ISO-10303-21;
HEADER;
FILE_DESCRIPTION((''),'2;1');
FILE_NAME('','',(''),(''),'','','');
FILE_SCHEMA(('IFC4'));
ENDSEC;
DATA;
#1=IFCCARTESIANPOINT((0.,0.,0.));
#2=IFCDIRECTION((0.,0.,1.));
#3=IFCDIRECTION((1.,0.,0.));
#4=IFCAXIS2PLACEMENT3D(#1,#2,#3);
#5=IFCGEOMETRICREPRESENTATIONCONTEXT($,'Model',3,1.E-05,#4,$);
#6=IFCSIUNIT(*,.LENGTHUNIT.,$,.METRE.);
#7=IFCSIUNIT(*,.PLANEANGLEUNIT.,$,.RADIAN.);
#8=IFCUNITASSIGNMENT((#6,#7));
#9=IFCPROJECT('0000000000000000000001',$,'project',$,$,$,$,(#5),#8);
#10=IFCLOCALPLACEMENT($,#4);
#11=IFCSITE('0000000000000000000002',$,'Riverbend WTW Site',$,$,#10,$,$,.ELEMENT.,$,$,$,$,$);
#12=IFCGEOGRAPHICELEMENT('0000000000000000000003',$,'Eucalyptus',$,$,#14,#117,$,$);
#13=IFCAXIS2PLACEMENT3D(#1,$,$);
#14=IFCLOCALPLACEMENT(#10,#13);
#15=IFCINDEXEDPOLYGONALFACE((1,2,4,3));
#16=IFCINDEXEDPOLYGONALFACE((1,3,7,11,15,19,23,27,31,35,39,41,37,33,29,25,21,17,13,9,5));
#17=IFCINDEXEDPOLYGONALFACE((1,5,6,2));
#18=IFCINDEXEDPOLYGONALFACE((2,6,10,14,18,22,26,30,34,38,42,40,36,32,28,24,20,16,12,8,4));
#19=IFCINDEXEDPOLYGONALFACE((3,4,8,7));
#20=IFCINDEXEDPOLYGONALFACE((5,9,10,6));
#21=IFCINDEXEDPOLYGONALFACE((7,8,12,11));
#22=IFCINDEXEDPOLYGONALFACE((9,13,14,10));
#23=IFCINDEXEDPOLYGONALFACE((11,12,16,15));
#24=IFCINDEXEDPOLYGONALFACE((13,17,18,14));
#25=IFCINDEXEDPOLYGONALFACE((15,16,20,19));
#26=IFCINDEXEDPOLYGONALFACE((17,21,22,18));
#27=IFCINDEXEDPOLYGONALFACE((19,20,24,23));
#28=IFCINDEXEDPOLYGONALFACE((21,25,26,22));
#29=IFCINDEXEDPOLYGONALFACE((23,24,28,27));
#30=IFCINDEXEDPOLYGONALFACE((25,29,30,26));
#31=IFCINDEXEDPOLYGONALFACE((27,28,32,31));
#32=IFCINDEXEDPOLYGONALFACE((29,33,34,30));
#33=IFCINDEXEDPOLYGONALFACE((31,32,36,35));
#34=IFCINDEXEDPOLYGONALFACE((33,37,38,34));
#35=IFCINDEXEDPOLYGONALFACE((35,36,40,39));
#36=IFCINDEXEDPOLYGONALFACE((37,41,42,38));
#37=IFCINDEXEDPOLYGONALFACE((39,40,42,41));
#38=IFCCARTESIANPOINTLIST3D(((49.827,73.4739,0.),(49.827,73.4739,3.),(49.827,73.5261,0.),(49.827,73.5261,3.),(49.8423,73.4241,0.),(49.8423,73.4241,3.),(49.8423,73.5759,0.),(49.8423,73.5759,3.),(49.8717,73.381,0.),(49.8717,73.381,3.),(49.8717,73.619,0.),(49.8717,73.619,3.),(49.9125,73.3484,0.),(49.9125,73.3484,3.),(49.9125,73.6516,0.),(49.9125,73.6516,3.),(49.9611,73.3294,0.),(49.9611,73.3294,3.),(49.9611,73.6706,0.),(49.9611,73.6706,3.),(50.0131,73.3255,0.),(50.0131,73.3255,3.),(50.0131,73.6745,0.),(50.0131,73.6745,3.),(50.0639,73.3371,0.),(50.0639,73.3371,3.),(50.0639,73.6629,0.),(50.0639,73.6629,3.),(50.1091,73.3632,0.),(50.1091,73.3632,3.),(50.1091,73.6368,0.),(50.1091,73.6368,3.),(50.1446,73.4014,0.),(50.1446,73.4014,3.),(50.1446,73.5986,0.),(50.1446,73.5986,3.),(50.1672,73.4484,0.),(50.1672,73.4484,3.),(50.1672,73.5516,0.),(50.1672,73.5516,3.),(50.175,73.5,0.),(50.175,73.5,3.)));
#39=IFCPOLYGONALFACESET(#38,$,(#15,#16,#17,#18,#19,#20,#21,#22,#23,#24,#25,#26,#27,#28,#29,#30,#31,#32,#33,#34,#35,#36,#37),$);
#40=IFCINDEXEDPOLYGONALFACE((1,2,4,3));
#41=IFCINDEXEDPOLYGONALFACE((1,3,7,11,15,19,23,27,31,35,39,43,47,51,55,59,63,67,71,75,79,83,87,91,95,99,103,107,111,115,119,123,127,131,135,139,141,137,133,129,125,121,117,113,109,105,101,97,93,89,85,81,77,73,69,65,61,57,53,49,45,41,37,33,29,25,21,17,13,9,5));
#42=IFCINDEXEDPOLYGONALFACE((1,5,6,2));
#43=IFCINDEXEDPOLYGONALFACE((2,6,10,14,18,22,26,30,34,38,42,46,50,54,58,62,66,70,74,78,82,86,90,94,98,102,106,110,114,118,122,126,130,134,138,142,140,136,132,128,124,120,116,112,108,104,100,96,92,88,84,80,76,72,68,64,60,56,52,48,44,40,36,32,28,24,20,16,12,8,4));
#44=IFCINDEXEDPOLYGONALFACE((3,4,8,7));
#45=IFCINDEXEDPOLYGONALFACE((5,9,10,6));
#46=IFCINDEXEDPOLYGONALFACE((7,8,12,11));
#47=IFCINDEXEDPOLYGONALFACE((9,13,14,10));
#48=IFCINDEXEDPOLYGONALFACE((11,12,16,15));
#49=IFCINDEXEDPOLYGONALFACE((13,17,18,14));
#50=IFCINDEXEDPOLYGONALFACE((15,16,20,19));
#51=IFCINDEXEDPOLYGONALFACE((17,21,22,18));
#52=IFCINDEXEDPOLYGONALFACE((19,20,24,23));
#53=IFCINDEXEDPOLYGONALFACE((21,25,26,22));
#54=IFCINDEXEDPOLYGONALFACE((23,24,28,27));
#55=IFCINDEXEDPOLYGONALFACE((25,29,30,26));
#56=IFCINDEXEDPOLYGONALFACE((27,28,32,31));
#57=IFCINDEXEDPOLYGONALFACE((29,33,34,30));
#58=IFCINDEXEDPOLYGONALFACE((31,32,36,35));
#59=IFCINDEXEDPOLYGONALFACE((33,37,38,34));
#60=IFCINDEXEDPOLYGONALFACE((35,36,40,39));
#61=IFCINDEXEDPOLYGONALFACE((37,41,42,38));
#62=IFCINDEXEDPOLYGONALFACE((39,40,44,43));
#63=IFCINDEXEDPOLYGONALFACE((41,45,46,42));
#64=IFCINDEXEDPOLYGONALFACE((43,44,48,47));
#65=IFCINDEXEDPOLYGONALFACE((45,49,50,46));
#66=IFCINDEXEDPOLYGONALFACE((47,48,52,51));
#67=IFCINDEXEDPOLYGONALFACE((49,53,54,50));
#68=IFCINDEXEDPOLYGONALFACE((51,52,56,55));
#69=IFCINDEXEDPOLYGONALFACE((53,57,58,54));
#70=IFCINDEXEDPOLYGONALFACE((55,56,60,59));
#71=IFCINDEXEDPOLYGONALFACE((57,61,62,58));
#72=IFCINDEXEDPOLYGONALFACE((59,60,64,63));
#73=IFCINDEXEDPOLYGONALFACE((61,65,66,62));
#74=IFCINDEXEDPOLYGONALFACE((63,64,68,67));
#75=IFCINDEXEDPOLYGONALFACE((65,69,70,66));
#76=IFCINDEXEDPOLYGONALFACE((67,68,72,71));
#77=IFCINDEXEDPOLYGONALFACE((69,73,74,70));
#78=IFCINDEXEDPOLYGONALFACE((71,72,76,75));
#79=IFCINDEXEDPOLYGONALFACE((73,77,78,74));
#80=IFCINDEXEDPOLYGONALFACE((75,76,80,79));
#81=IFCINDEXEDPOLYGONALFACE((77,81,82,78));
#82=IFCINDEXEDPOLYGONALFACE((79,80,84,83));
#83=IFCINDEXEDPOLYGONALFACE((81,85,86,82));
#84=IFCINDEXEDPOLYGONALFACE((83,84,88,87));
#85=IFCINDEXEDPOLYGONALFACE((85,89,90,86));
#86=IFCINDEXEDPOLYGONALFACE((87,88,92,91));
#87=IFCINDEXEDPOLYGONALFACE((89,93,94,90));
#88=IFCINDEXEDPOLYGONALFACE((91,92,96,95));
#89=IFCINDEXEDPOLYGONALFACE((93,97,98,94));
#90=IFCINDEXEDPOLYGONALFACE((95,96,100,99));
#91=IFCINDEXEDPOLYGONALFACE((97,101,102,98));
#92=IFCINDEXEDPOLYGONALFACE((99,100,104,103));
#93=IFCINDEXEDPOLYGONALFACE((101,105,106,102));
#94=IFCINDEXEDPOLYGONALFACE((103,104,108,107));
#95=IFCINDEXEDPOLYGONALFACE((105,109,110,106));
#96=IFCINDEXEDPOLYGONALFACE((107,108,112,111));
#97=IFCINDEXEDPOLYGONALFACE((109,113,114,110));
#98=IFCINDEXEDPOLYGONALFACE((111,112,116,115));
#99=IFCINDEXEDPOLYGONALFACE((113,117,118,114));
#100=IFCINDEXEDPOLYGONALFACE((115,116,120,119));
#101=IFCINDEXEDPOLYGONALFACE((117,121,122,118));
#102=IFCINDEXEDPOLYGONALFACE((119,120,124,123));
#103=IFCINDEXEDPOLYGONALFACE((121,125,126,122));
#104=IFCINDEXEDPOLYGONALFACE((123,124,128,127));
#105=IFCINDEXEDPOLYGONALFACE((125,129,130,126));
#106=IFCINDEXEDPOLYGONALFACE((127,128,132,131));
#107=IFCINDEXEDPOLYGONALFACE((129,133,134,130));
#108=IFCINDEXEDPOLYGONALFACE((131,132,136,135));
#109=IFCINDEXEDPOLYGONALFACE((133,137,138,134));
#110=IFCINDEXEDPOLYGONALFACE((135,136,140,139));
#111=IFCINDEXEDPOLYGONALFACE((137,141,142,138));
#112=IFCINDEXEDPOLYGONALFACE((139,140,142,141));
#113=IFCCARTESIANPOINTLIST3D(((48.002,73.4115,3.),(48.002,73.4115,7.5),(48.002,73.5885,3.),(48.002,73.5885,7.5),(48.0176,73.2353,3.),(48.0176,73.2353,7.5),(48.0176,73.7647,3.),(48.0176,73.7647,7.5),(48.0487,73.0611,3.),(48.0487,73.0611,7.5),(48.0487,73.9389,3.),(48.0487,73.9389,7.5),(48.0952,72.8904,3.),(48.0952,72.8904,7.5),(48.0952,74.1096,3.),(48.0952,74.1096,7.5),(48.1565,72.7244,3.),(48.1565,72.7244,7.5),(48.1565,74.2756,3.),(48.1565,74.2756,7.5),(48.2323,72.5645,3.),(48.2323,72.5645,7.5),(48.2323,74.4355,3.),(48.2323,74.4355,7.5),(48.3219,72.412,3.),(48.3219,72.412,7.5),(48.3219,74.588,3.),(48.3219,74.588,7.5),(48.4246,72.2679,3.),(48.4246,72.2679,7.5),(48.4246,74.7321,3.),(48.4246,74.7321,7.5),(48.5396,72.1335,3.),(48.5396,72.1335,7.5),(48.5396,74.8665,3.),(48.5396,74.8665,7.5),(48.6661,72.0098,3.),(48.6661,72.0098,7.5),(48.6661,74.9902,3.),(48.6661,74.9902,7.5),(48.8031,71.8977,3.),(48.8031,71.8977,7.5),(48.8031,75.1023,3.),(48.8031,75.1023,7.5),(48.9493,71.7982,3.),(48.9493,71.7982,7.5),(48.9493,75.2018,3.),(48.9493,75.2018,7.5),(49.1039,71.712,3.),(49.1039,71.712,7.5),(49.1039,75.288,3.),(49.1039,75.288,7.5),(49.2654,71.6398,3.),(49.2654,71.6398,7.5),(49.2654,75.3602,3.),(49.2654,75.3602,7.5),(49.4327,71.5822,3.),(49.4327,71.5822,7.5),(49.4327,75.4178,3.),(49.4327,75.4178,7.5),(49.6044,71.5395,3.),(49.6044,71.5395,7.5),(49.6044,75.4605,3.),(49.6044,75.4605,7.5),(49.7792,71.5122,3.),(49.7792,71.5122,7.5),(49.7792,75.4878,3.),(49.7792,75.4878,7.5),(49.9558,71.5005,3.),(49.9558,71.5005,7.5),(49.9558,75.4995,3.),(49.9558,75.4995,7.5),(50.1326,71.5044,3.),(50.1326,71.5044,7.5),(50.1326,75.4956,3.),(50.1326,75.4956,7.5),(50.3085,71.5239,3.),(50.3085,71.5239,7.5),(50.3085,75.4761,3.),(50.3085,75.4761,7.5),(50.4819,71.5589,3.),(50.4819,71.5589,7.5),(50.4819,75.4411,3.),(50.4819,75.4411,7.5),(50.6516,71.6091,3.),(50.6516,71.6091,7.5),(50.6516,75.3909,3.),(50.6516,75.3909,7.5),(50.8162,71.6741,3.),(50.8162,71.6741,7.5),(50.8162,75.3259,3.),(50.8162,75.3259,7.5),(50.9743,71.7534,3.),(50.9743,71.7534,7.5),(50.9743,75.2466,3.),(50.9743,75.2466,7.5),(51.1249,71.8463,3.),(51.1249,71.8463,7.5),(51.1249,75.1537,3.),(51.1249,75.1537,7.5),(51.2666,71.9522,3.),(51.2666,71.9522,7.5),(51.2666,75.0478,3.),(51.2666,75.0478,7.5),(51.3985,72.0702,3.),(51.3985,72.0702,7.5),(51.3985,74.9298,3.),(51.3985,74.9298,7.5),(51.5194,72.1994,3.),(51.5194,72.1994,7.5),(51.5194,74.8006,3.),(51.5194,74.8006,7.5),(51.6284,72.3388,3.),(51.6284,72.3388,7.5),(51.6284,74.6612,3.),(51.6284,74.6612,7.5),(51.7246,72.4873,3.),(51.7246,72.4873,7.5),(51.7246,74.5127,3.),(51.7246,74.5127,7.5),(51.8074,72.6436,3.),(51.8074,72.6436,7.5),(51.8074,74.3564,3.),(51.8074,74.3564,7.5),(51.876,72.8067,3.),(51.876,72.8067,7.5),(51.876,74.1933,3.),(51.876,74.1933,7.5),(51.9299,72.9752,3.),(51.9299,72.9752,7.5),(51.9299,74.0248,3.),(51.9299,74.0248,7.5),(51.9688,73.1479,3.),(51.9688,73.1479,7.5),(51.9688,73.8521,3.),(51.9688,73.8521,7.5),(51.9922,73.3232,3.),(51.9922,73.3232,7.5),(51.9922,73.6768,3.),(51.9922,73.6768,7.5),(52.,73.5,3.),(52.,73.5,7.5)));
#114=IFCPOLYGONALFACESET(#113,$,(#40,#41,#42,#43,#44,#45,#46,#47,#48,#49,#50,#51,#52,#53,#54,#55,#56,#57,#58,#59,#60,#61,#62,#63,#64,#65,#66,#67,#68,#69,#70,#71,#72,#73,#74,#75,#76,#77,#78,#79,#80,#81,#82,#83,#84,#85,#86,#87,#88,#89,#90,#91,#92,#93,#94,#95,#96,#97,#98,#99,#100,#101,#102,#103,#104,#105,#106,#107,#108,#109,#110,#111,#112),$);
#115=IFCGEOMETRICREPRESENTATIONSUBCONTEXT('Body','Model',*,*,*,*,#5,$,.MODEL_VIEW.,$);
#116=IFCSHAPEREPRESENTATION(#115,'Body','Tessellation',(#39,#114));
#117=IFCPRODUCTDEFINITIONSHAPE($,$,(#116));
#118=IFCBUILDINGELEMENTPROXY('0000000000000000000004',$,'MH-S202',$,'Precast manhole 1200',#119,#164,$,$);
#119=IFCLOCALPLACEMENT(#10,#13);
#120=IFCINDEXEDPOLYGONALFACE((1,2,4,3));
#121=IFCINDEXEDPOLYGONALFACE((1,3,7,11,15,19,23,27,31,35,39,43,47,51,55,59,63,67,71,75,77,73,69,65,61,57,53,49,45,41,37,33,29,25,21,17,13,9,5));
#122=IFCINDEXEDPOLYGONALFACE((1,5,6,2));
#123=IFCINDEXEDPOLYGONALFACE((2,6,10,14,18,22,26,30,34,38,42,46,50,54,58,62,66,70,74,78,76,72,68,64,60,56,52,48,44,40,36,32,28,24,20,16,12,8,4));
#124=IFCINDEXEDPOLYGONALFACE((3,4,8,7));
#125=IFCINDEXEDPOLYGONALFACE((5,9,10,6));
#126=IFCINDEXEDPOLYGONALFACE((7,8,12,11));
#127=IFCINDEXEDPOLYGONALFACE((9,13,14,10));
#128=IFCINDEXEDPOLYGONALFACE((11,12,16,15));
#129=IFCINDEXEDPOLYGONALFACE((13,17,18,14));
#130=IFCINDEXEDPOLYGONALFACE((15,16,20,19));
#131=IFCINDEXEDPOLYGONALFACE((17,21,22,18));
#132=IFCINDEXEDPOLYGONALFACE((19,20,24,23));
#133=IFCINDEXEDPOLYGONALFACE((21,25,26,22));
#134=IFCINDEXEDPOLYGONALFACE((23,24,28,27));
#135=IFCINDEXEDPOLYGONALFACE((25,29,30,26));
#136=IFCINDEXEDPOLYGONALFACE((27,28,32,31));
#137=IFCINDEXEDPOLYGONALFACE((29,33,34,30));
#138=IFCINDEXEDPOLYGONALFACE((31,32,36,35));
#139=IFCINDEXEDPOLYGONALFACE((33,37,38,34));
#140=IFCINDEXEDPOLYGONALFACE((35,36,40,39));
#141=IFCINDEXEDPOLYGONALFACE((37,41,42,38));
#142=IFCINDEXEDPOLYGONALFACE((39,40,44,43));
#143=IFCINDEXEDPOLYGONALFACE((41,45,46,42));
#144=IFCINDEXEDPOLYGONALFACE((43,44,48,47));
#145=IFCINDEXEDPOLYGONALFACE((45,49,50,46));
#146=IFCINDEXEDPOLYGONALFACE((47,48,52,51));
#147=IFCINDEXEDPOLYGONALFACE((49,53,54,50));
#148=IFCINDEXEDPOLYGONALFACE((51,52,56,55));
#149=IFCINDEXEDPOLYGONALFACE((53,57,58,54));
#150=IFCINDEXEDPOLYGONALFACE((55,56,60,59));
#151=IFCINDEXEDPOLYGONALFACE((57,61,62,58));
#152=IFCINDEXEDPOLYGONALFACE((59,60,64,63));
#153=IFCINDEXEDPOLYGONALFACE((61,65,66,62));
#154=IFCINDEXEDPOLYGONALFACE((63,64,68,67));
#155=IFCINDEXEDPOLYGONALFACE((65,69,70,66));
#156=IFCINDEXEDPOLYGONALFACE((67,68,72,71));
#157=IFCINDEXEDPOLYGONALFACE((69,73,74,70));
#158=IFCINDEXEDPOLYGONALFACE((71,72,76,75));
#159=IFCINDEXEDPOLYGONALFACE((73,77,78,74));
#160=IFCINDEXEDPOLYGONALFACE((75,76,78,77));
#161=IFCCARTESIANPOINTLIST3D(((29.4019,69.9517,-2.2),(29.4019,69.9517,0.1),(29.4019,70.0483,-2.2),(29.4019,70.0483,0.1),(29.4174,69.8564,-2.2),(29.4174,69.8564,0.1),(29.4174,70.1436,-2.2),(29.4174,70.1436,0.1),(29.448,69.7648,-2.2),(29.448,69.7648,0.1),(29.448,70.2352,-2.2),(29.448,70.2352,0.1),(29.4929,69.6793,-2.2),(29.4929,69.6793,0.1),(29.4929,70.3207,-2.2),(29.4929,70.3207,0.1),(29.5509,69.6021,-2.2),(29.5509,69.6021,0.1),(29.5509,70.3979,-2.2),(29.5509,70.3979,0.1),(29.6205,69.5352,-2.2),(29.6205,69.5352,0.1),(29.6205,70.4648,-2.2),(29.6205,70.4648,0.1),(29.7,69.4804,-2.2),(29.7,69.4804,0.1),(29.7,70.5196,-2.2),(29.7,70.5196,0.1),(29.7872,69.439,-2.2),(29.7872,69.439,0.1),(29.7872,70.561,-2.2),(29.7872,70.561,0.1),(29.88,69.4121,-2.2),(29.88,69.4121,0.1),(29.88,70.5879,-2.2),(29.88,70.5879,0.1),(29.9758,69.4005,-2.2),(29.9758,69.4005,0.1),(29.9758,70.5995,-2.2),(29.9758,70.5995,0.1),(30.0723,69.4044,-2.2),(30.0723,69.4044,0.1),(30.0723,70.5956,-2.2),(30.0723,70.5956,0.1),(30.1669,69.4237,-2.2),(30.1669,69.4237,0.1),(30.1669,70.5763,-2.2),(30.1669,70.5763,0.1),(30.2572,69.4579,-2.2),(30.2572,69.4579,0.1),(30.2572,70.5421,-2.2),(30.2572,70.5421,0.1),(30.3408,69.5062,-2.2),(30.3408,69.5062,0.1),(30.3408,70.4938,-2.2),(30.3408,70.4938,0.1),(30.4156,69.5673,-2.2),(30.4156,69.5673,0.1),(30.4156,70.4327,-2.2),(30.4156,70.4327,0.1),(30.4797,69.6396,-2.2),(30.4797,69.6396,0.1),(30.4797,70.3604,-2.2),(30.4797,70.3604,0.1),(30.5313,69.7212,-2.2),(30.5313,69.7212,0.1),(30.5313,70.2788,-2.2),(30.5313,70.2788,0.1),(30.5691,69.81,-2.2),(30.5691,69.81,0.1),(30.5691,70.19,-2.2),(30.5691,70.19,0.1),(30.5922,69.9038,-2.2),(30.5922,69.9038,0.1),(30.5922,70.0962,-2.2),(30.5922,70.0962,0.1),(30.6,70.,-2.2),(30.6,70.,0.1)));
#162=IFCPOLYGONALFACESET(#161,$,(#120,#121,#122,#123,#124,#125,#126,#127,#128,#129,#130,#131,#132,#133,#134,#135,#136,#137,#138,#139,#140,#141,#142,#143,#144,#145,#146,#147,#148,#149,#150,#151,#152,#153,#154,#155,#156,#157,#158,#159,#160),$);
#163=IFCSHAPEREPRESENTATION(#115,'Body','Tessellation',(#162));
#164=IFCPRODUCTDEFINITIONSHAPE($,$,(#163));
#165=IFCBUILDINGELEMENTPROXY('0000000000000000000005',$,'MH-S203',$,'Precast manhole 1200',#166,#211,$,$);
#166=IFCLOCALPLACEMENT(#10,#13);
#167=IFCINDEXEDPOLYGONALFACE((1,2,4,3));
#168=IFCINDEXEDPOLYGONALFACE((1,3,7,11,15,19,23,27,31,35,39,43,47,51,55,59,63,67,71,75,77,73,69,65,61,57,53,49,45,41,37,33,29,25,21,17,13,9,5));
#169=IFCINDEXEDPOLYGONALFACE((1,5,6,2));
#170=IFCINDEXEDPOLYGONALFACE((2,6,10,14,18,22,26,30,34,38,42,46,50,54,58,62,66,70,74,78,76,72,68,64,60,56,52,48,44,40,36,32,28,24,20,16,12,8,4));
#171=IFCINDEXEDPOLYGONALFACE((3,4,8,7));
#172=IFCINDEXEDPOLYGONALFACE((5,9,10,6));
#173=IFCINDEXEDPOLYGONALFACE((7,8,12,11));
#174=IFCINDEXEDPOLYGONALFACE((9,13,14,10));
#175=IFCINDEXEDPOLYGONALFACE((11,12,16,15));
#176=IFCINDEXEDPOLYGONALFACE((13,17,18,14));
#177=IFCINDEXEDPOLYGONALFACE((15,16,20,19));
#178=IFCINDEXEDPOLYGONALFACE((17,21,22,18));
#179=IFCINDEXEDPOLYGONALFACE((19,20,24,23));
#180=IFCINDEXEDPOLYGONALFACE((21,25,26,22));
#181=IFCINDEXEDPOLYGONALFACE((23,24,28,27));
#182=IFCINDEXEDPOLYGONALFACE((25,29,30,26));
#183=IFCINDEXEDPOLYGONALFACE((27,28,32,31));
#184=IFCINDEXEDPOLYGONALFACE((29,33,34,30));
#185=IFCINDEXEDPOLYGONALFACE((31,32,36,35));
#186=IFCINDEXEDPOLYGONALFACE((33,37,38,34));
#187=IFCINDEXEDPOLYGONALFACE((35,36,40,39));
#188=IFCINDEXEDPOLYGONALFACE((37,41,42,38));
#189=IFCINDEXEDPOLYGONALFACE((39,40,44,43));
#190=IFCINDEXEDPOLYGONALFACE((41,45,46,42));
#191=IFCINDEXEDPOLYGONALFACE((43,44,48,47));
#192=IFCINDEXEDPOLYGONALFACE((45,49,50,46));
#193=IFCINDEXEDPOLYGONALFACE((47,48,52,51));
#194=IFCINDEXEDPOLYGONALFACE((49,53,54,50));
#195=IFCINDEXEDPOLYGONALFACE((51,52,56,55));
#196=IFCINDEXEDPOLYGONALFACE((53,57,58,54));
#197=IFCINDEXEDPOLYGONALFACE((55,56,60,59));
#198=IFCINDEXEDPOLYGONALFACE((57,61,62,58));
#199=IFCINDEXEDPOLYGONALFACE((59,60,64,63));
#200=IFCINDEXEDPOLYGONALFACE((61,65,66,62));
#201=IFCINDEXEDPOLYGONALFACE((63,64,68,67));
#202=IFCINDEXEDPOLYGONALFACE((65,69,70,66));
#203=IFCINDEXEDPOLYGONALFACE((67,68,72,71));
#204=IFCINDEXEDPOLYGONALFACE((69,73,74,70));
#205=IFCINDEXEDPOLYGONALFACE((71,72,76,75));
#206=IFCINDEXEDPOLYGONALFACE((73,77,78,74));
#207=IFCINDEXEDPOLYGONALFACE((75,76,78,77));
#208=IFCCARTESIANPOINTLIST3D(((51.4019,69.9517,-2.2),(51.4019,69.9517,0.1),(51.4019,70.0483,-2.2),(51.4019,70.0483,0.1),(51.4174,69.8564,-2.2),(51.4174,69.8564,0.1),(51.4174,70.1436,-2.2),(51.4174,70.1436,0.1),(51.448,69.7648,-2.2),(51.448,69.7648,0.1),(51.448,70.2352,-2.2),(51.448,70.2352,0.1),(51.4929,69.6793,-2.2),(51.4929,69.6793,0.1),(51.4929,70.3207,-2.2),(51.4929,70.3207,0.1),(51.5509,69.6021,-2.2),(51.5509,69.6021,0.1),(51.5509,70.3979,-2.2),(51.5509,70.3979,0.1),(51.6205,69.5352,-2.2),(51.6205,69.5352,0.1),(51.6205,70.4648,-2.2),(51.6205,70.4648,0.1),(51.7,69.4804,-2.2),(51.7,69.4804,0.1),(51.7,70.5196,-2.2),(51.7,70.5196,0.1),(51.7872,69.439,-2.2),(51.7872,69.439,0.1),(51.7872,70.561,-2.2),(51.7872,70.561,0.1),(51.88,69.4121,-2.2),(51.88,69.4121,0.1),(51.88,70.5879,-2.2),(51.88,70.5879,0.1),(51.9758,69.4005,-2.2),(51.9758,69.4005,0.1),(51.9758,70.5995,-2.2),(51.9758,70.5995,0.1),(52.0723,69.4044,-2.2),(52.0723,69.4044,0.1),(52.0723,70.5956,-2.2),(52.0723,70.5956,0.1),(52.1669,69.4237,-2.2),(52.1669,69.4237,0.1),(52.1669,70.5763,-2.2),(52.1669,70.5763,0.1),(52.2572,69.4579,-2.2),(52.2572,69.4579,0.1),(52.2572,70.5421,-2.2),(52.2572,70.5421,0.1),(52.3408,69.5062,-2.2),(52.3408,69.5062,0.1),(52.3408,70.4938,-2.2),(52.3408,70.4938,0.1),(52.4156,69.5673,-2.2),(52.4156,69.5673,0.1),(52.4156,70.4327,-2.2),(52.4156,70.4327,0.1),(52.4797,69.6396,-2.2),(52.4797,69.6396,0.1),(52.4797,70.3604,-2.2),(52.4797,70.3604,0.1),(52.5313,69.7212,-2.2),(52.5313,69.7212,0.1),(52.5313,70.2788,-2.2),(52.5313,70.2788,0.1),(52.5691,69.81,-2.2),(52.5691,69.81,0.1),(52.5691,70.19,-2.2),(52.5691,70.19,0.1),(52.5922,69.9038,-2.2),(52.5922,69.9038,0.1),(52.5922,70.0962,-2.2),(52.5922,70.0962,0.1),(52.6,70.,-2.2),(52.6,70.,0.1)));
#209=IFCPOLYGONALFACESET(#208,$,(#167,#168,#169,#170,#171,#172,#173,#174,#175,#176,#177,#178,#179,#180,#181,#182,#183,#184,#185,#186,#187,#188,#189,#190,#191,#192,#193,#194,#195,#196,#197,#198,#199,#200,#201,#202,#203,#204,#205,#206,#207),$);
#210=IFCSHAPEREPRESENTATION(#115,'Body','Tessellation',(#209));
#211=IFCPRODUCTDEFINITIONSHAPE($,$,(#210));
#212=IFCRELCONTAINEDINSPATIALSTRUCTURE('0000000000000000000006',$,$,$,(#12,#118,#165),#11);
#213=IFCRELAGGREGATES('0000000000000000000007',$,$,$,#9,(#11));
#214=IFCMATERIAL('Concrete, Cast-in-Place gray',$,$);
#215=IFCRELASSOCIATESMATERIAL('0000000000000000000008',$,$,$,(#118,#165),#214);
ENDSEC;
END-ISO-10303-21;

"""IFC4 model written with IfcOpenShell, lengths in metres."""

from ifc_helpers import new_model, si_unit, frame, origin_with_axes, origin_2d, place, context, subcontext, project, spatial, circle, extrude, material, element, save


model = new_model("IFC4")

# Units and contexts
model_context = context("Model", 3, precision=1e-05, world=origin_with_axes())
body_context = subcontext(model_context, "Body", "Model", "MODEL_VIEW")
ifc_project = project(units=[si_unit("LENGTHUNIT", "METRE"), si_unit("PLANEANGLEUNIT", "RADIAN")], contexts=[model_context])

# Site
site_placement = place(None, origin_with_axes())
site = spatial("IfcSite", under=ifc_project, at=site_placement, Name="Riverbend WTW Site", CompositionType="ELEMENT")

# Shared definitions
ifc_material_1 = material(Name="Concrete, Cast-in-Place gray")

# Geographic element
for number, where, z_axis, x_axis, name in (
    (1, (50.0, 73.5, 0.0), (0.0, 0.0, 1.0), (1.0, 0.0, 0.0), "Eucalyptus"),
):
    element("IfcGeographicElement", number, at=place(None, frame(where, z_axis=z_axis, x_axis=x_axis)), inside=site, Name=name, context=body_context, shape_type="SweptSolid", body=[
        extrude(circle(Radius=0.175, at=origin_2d()), origin_with_axes(), (0.0, 0.0, 1.0), 3.0),
        extrude(circle(Radius=2.0, at=origin_2d()), frame((0.0, 0.0, 3.0), z_axis=(0.0, 0.0, 1.0), x_axis=(1.0, 0.0, 0.0)), (0.0, 0.0, 1.0), 4.5),
    ])

# Building element proxies
for number, where, z_axis, x_axis, name in (
    (2, (30.0, 70.0, -2.2), (0.0, 0.0, 1.0), (1.0, 0.0, 0.0), "MH-S202"),
    (3, (52.0, 70.0, -2.2), (0.0, 0.0, 1.0), (1.0, 0.0, 0.0), "MH-S203"),
):
    element("IfcBuildingElementProxy", number, at=place(None, frame(where, z_axis=z_axis, x_axis=x_axis)), inside=site, material=ifc_material_1, Name=name, ObjectType="Precast manhole 1200", context=body_context, shape_type="SweptSolid", body=[
        extrude(circle(Radius=0.6, at=origin_2d()), origin_with_axes(), (0.0, 0.0, 1.0), 2.3),
    ])

save(model, "model.ifc")
